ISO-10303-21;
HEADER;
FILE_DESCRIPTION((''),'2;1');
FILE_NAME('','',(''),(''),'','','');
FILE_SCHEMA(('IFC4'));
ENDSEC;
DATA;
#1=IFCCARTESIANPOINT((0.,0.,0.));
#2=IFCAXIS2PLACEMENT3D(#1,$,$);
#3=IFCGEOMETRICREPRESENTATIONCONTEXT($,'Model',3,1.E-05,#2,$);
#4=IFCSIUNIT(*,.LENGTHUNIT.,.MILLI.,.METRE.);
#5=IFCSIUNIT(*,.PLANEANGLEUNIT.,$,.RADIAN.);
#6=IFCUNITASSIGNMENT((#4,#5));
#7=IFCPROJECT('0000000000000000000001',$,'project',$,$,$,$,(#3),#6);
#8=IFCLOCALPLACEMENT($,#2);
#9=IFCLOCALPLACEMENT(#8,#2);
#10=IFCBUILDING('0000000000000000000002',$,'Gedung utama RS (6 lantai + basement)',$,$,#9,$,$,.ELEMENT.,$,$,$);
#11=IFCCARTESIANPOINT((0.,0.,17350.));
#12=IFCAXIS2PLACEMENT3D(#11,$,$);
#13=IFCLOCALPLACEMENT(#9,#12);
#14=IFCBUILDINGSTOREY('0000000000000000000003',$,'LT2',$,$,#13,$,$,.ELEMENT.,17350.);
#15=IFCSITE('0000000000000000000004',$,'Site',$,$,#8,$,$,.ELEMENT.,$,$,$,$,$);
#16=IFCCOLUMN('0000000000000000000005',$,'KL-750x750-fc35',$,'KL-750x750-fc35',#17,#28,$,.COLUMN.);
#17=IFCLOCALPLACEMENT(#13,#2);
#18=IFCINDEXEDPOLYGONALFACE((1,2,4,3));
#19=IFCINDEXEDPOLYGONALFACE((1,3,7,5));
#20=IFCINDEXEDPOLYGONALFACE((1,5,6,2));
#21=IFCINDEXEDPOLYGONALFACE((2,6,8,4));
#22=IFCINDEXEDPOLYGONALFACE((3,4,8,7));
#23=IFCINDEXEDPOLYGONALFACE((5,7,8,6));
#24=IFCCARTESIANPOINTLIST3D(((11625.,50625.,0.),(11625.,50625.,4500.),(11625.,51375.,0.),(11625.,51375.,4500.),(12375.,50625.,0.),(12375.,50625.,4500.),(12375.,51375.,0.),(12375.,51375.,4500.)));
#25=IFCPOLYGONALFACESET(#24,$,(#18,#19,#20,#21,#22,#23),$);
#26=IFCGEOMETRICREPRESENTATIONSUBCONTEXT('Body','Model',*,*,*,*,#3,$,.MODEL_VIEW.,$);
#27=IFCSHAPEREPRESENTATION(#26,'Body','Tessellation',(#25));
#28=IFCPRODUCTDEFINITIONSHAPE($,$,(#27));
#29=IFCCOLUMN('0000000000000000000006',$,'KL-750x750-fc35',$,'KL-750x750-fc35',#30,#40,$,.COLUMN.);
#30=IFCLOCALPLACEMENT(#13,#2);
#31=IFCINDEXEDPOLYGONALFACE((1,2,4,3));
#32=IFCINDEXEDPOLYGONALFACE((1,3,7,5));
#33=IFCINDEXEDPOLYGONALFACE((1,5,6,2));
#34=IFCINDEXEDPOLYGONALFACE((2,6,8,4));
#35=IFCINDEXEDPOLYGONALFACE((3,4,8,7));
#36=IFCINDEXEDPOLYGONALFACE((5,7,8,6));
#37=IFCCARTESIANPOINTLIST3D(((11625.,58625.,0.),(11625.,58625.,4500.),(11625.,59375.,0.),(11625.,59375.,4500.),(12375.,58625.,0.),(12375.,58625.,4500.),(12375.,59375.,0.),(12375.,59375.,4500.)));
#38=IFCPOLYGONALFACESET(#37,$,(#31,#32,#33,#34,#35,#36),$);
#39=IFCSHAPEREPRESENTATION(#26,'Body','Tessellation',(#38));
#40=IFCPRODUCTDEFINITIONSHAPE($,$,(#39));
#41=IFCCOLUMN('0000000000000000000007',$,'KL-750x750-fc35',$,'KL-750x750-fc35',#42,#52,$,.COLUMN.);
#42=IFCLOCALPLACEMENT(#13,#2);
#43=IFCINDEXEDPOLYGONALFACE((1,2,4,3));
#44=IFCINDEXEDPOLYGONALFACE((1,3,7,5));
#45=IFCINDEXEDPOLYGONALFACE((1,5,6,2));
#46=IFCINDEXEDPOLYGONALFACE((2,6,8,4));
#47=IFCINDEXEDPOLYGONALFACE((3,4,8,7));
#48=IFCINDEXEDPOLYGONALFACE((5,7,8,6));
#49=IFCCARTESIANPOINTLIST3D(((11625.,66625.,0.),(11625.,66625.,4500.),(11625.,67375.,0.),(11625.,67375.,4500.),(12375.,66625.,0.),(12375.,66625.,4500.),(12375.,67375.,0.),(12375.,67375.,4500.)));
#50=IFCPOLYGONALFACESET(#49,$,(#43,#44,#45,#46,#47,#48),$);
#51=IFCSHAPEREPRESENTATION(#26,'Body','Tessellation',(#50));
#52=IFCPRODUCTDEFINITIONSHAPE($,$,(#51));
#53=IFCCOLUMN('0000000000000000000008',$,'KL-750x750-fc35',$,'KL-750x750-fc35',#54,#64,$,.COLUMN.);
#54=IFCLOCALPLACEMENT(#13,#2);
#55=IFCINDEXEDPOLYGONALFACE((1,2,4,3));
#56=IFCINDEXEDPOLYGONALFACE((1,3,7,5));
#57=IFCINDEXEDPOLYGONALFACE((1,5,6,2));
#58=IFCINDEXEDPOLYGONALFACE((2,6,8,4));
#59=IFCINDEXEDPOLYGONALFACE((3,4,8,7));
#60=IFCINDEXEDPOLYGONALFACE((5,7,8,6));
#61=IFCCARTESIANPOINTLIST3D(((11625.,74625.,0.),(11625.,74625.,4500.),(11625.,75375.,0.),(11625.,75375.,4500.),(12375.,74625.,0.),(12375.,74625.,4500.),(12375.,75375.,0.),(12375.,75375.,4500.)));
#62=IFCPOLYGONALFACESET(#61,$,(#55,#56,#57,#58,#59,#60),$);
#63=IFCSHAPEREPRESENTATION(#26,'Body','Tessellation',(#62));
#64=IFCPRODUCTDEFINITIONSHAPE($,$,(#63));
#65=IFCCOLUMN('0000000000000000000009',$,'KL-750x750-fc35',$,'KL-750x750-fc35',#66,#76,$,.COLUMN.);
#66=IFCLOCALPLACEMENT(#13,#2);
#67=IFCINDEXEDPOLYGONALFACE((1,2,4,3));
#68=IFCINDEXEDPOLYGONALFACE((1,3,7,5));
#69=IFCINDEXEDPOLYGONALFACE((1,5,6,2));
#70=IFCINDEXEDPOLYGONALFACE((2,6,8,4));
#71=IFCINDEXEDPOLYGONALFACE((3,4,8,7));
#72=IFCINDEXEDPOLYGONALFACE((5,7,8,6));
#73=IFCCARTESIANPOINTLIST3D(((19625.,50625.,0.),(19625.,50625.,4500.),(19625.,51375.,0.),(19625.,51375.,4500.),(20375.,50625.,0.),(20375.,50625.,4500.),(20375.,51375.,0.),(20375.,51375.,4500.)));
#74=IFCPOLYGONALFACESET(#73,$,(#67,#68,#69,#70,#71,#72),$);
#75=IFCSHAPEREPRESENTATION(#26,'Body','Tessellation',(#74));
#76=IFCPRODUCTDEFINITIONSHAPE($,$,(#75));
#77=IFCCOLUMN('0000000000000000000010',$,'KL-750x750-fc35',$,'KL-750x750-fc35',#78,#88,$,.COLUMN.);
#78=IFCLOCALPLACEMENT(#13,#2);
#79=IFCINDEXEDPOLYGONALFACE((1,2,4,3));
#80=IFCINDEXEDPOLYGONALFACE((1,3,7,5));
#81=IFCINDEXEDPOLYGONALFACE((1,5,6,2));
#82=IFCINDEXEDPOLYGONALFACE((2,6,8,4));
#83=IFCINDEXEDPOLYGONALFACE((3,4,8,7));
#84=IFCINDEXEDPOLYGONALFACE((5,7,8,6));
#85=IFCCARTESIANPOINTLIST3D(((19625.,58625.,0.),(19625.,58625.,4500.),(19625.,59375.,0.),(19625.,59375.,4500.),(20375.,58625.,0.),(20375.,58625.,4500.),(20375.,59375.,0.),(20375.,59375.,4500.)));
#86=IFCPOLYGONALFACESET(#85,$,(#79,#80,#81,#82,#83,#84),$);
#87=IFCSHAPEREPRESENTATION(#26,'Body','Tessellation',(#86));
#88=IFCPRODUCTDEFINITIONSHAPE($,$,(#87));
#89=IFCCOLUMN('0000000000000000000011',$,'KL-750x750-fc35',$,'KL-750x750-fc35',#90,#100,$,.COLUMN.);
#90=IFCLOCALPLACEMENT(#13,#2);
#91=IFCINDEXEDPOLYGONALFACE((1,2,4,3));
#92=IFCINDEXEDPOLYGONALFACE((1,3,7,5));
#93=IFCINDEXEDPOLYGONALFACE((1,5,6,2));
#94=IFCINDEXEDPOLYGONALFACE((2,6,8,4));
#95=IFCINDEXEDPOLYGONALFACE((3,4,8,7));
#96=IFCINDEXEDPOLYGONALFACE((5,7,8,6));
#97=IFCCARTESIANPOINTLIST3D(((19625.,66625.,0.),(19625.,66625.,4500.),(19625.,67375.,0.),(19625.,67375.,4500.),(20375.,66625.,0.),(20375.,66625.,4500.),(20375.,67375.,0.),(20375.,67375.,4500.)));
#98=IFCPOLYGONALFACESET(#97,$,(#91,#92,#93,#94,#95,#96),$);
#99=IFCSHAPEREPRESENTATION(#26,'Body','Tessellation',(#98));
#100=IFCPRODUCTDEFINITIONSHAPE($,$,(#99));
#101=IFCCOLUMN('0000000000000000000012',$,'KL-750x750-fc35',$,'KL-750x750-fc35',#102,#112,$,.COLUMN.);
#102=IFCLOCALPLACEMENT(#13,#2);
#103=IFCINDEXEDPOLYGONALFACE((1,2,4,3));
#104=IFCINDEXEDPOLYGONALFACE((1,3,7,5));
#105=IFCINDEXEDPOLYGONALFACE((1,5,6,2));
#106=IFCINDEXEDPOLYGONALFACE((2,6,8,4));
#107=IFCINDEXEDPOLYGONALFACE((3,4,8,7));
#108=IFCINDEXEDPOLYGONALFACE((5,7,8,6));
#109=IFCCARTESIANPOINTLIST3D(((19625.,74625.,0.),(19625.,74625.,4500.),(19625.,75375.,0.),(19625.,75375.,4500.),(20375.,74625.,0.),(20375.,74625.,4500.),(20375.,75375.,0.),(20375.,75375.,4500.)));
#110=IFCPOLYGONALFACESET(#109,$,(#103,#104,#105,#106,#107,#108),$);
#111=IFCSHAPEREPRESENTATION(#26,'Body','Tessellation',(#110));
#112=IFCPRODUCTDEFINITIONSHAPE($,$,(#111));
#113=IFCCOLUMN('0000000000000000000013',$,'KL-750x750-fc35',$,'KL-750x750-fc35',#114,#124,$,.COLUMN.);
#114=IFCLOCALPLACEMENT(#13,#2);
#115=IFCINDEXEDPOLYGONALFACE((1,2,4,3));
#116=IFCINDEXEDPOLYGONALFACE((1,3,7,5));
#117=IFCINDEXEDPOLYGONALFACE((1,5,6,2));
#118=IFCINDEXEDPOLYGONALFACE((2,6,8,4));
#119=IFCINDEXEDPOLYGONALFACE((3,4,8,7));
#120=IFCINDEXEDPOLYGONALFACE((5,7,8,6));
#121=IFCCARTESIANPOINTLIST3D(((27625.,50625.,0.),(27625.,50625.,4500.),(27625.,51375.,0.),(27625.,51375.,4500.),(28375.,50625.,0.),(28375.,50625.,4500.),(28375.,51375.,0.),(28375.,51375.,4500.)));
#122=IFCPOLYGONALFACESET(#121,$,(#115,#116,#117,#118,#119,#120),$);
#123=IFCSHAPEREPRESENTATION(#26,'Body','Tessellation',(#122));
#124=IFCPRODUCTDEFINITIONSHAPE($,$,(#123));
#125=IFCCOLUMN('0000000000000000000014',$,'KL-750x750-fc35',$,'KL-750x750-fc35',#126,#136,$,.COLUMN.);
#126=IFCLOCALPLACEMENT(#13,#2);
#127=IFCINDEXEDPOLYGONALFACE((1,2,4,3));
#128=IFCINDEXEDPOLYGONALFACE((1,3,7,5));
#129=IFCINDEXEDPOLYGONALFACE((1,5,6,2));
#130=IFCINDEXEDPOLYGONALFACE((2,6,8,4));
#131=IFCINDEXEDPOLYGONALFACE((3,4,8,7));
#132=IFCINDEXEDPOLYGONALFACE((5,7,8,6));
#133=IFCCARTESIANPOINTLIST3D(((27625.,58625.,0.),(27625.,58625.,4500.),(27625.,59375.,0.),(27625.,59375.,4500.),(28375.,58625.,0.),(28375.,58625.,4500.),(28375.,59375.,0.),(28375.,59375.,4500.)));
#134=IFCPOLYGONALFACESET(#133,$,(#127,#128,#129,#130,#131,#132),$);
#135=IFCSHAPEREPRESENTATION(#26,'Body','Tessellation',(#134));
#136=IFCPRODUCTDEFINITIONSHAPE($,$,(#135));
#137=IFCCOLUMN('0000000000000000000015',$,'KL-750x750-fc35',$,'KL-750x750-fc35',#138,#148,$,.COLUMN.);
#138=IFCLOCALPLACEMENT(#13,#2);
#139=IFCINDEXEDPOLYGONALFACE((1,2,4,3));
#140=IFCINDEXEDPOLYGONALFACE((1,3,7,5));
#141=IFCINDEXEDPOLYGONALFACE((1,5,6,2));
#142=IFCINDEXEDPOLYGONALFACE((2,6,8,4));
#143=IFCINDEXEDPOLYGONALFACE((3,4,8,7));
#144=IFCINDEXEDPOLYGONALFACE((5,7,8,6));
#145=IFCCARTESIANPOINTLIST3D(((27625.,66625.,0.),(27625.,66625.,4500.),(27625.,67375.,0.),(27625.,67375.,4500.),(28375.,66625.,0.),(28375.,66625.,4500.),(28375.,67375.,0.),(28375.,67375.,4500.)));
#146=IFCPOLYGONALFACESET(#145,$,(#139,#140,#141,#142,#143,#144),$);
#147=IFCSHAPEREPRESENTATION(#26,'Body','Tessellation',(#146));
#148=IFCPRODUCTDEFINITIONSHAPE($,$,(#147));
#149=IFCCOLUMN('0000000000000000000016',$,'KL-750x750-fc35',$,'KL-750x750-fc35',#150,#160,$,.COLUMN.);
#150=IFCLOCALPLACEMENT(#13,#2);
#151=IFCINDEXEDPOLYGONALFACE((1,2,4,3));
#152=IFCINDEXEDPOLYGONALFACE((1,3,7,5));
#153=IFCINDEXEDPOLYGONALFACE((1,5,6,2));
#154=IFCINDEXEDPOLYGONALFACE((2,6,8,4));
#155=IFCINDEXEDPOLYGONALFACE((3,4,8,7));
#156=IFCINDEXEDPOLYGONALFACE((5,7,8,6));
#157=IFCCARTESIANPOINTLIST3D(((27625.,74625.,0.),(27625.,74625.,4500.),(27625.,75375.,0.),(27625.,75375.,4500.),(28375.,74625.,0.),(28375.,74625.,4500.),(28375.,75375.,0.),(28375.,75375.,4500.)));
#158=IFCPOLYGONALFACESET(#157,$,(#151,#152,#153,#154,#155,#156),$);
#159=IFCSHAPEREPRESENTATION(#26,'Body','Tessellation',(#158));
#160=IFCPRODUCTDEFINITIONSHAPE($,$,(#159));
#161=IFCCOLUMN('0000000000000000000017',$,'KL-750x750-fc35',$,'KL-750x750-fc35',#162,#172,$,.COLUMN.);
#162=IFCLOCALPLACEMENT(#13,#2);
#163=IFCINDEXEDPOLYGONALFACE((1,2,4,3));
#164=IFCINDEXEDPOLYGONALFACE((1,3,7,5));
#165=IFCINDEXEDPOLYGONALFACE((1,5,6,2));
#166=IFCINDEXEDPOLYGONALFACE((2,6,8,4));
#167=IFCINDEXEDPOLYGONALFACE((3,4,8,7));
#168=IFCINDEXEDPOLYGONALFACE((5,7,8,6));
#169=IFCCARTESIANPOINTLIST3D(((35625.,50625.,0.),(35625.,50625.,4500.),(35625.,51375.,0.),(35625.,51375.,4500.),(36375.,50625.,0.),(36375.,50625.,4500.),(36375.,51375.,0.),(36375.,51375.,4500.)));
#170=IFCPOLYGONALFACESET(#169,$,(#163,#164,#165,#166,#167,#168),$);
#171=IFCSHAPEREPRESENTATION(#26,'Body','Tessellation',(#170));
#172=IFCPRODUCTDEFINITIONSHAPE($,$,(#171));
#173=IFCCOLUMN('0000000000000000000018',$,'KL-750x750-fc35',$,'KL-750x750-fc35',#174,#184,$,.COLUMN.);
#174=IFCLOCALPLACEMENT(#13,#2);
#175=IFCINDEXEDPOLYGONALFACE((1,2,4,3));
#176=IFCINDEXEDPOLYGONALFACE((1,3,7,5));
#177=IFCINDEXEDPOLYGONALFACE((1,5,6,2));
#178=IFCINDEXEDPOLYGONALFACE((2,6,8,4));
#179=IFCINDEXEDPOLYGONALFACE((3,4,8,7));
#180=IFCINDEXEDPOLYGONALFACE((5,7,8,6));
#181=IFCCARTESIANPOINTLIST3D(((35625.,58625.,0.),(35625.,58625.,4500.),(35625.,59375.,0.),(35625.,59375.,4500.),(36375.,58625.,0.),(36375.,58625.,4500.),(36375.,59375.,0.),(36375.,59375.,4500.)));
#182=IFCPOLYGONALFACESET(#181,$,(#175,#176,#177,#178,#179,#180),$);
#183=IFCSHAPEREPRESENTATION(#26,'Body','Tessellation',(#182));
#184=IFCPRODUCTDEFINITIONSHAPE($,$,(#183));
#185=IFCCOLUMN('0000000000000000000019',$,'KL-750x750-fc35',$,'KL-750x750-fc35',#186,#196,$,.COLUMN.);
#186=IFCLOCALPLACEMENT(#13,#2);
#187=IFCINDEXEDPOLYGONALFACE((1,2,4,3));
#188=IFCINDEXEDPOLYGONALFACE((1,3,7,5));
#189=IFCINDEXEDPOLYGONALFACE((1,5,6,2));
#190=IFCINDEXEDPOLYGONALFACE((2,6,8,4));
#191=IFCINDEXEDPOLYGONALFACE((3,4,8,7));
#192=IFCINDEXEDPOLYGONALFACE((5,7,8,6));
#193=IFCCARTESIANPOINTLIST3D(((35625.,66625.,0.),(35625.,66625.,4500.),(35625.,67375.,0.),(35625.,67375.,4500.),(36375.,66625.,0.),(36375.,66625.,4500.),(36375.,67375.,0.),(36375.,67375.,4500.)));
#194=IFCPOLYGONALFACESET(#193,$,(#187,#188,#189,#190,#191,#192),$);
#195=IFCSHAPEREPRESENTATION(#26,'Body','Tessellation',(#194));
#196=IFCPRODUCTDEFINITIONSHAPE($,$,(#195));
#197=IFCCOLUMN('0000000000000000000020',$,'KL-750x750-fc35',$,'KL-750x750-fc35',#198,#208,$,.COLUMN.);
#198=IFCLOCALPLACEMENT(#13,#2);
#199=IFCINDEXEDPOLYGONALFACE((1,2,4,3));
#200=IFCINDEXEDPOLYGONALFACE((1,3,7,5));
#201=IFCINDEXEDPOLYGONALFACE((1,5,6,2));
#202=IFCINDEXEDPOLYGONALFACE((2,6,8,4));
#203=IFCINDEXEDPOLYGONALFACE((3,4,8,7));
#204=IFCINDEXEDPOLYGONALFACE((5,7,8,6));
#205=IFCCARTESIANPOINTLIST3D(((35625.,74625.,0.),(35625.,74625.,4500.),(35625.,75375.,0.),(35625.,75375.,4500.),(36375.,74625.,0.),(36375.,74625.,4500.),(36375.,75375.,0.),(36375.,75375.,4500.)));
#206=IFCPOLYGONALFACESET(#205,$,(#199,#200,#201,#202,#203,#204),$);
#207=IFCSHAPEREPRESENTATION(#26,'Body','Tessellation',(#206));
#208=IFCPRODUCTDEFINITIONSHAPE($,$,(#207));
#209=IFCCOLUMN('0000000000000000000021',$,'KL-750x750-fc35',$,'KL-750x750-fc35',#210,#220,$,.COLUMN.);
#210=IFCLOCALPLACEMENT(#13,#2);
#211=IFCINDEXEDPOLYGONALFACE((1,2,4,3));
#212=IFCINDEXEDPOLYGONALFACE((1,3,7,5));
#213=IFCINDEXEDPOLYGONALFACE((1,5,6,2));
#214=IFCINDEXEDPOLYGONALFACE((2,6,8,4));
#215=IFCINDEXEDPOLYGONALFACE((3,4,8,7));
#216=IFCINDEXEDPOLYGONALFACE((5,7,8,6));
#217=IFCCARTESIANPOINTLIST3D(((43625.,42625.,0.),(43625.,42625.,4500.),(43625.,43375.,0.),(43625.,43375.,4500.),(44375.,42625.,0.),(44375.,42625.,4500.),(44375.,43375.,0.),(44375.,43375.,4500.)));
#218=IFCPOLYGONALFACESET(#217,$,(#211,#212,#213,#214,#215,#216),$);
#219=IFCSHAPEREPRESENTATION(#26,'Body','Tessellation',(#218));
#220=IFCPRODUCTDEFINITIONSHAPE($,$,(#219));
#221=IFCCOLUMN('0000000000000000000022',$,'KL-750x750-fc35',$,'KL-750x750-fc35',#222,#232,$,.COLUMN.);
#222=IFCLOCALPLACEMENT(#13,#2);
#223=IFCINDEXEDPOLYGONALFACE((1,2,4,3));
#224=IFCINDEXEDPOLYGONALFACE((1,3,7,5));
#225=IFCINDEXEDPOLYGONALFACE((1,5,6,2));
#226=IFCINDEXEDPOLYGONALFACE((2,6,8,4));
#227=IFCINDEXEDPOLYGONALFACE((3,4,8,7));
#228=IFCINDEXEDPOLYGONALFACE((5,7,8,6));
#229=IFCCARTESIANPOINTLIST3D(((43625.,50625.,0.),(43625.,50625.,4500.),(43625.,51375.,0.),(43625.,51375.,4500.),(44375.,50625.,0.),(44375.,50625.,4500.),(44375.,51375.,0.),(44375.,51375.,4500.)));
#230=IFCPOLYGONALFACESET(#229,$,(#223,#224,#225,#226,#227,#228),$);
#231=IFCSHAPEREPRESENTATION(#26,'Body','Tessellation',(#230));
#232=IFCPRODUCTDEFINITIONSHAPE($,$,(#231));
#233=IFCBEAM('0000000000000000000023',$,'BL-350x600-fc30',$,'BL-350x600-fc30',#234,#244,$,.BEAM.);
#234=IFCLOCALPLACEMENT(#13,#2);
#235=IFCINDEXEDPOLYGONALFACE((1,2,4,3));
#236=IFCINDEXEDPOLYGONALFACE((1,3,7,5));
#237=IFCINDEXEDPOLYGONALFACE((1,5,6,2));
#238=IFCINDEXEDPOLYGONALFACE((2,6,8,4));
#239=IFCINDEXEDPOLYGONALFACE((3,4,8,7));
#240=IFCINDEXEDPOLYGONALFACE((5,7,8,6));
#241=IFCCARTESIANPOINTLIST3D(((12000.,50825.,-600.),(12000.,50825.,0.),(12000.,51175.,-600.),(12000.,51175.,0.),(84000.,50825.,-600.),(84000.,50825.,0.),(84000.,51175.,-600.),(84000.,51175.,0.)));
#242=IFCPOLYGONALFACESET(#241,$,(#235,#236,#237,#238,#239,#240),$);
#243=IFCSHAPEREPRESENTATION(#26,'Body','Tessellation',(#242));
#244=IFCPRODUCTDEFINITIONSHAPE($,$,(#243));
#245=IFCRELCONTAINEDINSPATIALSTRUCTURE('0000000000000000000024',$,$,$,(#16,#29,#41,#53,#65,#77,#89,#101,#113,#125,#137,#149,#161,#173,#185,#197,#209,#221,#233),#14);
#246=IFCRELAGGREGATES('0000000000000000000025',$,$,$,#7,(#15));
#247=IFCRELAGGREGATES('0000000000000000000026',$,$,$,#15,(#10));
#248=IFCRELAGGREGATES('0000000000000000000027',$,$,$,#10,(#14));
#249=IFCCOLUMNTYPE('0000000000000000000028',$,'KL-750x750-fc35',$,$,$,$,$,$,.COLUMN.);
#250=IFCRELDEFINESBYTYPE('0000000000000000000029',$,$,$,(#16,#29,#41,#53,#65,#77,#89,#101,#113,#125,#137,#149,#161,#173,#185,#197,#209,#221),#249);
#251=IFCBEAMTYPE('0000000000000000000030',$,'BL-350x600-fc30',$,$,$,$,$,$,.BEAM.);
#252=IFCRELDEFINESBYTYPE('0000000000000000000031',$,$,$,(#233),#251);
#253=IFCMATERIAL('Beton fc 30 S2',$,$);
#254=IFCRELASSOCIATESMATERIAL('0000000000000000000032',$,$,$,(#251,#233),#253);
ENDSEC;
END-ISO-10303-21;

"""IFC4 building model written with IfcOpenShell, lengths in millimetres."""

from ifc_helpers import new_model, si_unit, frame, origin, origin_2d, place, context, subcontext, project, spatial, rectangle, extrude, material, material_profile, profile_set, profile_usage, type_object, element, save


model = new_model("IFC4")

# Units and contexts
model_context = context("Model", 3, precision=1e-05, world=origin())
body_context = subcontext(model_context, "Body", "Model", "MODEL_VIEW")
ifc_project = project(units=[si_unit("LENGTHUNIT", "METRE", prefix="MILLI"), si_unit("PLANEANGLEUNIT", "RADIAN")], contexts=[model_context])

# Site, building, storey
site_placement = place(None, origin())
site = spatial("IfcSite", under=ifc_project, at=site_placement, Name="Site", CompositionType="ELEMENT")
building_placement = place(site_placement, origin())
building = spatial("IfcBuilding", under=site, at=building_placement, Name="Gedung utama RS (6 lantai + basement)", CompositionType="ELEMENT")
storey_placement = place(building_placement, frame((0.0, 0.0, 17350.0)))
storey = spatial("IfcBuildingStorey", under=building, at=storey_placement, Name="LT2", CompositionType="ELEMENT", Elevation=17350.0)

# Columns
ifc_material_profile_1 = material_profile(None, rectangle(XDim=750.0, YDim=750.0, at=origin_2d()), Name="KL-750x750-fc35")
ifc_profile_set_1 = profile_set([ifc_material_profile_1], Name="KL-750x750-fc35")
ifc_profile_usage_1 = profile_usage(ifc_profile_set_1, cardinal=5)
column_type = type_object("IfcColumnType", Name="KL-750x750-fc35", PredefinedType="COLUMN", material=ifc_profile_set_1)
for number, where, z_axis, x_axis, name in (
    (1, (12000.0, 51000.0, 0.0), (0.0, 0.0, 1.0), (1.0, 0.0, 0.0), "KL-750x750-fc35"),
    (2, (12000.0, 59000.0, 0.0), (0.0, 0.0, 1.0), (1.0, 0.0, 0.0), "KL-750x750-fc35"),
    (3, (12000.0, 67000.0, 0.0), (0.0, 0.0, 1.0), (1.0, 0.0, 0.0), "KL-750x750-fc35"),
    (4, (12000.0, 75000.0, 0.0), (0.0, 0.0, 1.0), (1.0, 0.0, 0.0), "KL-750x750-fc35"),
    (5, (20000.0, 51000.0, 0.0), (0.0, 0.0, 1.0), (1.0, 0.0, 0.0), "KL-750x750-fc35"),
    (6, (20000.0, 59000.0, 0.0), (0.0, 0.0, 1.0), (1.0, 0.0, 0.0), "KL-750x750-fc35"),
    (7, (20000.0, 67000.0, 0.0), (0.0, 0.0, 1.0), (1.0, 0.0, 0.0), "KL-750x750-fc35"),
    (8, (20000.0, 75000.0, 0.0), (0.0, 0.0, 1.0), (1.0, 0.0, 0.0), "KL-750x750-fc35"),
    (9, (28000.0, 51000.0, 0.0), (0.0, 0.0, 1.0), (1.0, 0.0, 0.0), "KL-750x750-fc35"),
    (10, (28000.0, 59000.0, 0.0), (0.0, 0.0, 1.0), (1.0, 0.0, 0.0), "KL-750x750-fc35"),
    (11, (28000.0, 67000.0, 0.0), (0.0, 0.0, 1.0), (1.0, 0.0, 0.0), "KL-750x750-fc35"),
    (12, (28000.0, 75000.0, 0.0), (0.0, 0.0, 1.0), (1.0, 0.0, 0.0), "KL-750x750-fc35"),
    (13, (36000.0, 51000.0, 0.0), (0.0, 0.0, 1.0), (1.0, 0.0, 0.0), "KL-750x750-fc35"),
    (14, (36000.0, 59000.0, 0.0), (0.0, 0.0, 1.0), (1.0, 0.0, 0.0), "KL-750x750-fc35"),
    (15, (36000.0, 67000.0, 0.0), (0.0, 0.0, 1.0), (1.0, 0.0, 0.0), "KL-750x750-fc35"),
    (16, (36000.0, 75000.0, 0.0), (0.0, 0.0, 1.0), (1.0, 0.0, 0.0), "KL-750x750-fc35"),
    (17, (44000.0, 43000.0, 0.0), (0.0, 0.0, 1.0), (1.0, 0.0, 0.0), "KL-750x750-fc35"),
    (18, (44000.0, 51000.0, 0.0), (0.0, 0.0, 1.0), (1.0, 0.0, 0.0), "KL-750x750-fc35"),
):
    element("IfcColumn", number, at=place(storey_placement, frame(where, z_axis=z_axis, x_axis=x_axis)), inside=storey, type_object=column_type, material=ifc_profile_usage_1, Name=name, ObjectType="KL-750x750-fc35", PredefinedType="COLUMN", context=body_context, shape_type="SweptSolid", body=[
        extrude(rectangle(XDim=750.0, YDim=750.0, at=origin_2d()), origin(), (0.0, 0.0, 1.0), 4500.0),
    ])

# Beam
ifc_material = material(Name="Beton fc 30 S2")
ifc_material_profile_2 = material_profile(ifc_material, rectangle(XDim=350.0, YDim=600.0, at=origin_2d()), Name="BL-350x600-fc30")
ifc_profile_set_2 = profile_set([ifc_material_profile_2], Name="BL-350x600-fc30")
ifc_profile_usage_2 = profile_usage(ifc_profile_set_2, cardinal=8)
beam_type = type_object("IfcBeamType", Name="BL-350x600-fc30", PredefinedType="BEAM", material=ifc_profile_set_2)
for number, where, name in (
    (19, (12000.0, 51000.0, -300.0), "BL-350x600-fc30"),
):
    element("IfcBeam", number, at=place(storey_placement, frame(where)), inside=storey, type_object=beam_type, material=ifc_profile_usage_2, Name=name, ObjectType="BL-350x600-fc30", PredefinedType="BEAM", context=body_context, shape_type="SweptSolid", body=[
        extrude(rectangle(XDim=350.0, YDim=600.0, at=origin_2d()), frame((0.0, 0.0, 0.0), z_axis=(1.0, 0.0, 0.0), x_axis=(0.0, 1.0, 0.0)), (0.0, 0.0, 1.0), 72000.0),
    ])

save(model, "model.ifc")
